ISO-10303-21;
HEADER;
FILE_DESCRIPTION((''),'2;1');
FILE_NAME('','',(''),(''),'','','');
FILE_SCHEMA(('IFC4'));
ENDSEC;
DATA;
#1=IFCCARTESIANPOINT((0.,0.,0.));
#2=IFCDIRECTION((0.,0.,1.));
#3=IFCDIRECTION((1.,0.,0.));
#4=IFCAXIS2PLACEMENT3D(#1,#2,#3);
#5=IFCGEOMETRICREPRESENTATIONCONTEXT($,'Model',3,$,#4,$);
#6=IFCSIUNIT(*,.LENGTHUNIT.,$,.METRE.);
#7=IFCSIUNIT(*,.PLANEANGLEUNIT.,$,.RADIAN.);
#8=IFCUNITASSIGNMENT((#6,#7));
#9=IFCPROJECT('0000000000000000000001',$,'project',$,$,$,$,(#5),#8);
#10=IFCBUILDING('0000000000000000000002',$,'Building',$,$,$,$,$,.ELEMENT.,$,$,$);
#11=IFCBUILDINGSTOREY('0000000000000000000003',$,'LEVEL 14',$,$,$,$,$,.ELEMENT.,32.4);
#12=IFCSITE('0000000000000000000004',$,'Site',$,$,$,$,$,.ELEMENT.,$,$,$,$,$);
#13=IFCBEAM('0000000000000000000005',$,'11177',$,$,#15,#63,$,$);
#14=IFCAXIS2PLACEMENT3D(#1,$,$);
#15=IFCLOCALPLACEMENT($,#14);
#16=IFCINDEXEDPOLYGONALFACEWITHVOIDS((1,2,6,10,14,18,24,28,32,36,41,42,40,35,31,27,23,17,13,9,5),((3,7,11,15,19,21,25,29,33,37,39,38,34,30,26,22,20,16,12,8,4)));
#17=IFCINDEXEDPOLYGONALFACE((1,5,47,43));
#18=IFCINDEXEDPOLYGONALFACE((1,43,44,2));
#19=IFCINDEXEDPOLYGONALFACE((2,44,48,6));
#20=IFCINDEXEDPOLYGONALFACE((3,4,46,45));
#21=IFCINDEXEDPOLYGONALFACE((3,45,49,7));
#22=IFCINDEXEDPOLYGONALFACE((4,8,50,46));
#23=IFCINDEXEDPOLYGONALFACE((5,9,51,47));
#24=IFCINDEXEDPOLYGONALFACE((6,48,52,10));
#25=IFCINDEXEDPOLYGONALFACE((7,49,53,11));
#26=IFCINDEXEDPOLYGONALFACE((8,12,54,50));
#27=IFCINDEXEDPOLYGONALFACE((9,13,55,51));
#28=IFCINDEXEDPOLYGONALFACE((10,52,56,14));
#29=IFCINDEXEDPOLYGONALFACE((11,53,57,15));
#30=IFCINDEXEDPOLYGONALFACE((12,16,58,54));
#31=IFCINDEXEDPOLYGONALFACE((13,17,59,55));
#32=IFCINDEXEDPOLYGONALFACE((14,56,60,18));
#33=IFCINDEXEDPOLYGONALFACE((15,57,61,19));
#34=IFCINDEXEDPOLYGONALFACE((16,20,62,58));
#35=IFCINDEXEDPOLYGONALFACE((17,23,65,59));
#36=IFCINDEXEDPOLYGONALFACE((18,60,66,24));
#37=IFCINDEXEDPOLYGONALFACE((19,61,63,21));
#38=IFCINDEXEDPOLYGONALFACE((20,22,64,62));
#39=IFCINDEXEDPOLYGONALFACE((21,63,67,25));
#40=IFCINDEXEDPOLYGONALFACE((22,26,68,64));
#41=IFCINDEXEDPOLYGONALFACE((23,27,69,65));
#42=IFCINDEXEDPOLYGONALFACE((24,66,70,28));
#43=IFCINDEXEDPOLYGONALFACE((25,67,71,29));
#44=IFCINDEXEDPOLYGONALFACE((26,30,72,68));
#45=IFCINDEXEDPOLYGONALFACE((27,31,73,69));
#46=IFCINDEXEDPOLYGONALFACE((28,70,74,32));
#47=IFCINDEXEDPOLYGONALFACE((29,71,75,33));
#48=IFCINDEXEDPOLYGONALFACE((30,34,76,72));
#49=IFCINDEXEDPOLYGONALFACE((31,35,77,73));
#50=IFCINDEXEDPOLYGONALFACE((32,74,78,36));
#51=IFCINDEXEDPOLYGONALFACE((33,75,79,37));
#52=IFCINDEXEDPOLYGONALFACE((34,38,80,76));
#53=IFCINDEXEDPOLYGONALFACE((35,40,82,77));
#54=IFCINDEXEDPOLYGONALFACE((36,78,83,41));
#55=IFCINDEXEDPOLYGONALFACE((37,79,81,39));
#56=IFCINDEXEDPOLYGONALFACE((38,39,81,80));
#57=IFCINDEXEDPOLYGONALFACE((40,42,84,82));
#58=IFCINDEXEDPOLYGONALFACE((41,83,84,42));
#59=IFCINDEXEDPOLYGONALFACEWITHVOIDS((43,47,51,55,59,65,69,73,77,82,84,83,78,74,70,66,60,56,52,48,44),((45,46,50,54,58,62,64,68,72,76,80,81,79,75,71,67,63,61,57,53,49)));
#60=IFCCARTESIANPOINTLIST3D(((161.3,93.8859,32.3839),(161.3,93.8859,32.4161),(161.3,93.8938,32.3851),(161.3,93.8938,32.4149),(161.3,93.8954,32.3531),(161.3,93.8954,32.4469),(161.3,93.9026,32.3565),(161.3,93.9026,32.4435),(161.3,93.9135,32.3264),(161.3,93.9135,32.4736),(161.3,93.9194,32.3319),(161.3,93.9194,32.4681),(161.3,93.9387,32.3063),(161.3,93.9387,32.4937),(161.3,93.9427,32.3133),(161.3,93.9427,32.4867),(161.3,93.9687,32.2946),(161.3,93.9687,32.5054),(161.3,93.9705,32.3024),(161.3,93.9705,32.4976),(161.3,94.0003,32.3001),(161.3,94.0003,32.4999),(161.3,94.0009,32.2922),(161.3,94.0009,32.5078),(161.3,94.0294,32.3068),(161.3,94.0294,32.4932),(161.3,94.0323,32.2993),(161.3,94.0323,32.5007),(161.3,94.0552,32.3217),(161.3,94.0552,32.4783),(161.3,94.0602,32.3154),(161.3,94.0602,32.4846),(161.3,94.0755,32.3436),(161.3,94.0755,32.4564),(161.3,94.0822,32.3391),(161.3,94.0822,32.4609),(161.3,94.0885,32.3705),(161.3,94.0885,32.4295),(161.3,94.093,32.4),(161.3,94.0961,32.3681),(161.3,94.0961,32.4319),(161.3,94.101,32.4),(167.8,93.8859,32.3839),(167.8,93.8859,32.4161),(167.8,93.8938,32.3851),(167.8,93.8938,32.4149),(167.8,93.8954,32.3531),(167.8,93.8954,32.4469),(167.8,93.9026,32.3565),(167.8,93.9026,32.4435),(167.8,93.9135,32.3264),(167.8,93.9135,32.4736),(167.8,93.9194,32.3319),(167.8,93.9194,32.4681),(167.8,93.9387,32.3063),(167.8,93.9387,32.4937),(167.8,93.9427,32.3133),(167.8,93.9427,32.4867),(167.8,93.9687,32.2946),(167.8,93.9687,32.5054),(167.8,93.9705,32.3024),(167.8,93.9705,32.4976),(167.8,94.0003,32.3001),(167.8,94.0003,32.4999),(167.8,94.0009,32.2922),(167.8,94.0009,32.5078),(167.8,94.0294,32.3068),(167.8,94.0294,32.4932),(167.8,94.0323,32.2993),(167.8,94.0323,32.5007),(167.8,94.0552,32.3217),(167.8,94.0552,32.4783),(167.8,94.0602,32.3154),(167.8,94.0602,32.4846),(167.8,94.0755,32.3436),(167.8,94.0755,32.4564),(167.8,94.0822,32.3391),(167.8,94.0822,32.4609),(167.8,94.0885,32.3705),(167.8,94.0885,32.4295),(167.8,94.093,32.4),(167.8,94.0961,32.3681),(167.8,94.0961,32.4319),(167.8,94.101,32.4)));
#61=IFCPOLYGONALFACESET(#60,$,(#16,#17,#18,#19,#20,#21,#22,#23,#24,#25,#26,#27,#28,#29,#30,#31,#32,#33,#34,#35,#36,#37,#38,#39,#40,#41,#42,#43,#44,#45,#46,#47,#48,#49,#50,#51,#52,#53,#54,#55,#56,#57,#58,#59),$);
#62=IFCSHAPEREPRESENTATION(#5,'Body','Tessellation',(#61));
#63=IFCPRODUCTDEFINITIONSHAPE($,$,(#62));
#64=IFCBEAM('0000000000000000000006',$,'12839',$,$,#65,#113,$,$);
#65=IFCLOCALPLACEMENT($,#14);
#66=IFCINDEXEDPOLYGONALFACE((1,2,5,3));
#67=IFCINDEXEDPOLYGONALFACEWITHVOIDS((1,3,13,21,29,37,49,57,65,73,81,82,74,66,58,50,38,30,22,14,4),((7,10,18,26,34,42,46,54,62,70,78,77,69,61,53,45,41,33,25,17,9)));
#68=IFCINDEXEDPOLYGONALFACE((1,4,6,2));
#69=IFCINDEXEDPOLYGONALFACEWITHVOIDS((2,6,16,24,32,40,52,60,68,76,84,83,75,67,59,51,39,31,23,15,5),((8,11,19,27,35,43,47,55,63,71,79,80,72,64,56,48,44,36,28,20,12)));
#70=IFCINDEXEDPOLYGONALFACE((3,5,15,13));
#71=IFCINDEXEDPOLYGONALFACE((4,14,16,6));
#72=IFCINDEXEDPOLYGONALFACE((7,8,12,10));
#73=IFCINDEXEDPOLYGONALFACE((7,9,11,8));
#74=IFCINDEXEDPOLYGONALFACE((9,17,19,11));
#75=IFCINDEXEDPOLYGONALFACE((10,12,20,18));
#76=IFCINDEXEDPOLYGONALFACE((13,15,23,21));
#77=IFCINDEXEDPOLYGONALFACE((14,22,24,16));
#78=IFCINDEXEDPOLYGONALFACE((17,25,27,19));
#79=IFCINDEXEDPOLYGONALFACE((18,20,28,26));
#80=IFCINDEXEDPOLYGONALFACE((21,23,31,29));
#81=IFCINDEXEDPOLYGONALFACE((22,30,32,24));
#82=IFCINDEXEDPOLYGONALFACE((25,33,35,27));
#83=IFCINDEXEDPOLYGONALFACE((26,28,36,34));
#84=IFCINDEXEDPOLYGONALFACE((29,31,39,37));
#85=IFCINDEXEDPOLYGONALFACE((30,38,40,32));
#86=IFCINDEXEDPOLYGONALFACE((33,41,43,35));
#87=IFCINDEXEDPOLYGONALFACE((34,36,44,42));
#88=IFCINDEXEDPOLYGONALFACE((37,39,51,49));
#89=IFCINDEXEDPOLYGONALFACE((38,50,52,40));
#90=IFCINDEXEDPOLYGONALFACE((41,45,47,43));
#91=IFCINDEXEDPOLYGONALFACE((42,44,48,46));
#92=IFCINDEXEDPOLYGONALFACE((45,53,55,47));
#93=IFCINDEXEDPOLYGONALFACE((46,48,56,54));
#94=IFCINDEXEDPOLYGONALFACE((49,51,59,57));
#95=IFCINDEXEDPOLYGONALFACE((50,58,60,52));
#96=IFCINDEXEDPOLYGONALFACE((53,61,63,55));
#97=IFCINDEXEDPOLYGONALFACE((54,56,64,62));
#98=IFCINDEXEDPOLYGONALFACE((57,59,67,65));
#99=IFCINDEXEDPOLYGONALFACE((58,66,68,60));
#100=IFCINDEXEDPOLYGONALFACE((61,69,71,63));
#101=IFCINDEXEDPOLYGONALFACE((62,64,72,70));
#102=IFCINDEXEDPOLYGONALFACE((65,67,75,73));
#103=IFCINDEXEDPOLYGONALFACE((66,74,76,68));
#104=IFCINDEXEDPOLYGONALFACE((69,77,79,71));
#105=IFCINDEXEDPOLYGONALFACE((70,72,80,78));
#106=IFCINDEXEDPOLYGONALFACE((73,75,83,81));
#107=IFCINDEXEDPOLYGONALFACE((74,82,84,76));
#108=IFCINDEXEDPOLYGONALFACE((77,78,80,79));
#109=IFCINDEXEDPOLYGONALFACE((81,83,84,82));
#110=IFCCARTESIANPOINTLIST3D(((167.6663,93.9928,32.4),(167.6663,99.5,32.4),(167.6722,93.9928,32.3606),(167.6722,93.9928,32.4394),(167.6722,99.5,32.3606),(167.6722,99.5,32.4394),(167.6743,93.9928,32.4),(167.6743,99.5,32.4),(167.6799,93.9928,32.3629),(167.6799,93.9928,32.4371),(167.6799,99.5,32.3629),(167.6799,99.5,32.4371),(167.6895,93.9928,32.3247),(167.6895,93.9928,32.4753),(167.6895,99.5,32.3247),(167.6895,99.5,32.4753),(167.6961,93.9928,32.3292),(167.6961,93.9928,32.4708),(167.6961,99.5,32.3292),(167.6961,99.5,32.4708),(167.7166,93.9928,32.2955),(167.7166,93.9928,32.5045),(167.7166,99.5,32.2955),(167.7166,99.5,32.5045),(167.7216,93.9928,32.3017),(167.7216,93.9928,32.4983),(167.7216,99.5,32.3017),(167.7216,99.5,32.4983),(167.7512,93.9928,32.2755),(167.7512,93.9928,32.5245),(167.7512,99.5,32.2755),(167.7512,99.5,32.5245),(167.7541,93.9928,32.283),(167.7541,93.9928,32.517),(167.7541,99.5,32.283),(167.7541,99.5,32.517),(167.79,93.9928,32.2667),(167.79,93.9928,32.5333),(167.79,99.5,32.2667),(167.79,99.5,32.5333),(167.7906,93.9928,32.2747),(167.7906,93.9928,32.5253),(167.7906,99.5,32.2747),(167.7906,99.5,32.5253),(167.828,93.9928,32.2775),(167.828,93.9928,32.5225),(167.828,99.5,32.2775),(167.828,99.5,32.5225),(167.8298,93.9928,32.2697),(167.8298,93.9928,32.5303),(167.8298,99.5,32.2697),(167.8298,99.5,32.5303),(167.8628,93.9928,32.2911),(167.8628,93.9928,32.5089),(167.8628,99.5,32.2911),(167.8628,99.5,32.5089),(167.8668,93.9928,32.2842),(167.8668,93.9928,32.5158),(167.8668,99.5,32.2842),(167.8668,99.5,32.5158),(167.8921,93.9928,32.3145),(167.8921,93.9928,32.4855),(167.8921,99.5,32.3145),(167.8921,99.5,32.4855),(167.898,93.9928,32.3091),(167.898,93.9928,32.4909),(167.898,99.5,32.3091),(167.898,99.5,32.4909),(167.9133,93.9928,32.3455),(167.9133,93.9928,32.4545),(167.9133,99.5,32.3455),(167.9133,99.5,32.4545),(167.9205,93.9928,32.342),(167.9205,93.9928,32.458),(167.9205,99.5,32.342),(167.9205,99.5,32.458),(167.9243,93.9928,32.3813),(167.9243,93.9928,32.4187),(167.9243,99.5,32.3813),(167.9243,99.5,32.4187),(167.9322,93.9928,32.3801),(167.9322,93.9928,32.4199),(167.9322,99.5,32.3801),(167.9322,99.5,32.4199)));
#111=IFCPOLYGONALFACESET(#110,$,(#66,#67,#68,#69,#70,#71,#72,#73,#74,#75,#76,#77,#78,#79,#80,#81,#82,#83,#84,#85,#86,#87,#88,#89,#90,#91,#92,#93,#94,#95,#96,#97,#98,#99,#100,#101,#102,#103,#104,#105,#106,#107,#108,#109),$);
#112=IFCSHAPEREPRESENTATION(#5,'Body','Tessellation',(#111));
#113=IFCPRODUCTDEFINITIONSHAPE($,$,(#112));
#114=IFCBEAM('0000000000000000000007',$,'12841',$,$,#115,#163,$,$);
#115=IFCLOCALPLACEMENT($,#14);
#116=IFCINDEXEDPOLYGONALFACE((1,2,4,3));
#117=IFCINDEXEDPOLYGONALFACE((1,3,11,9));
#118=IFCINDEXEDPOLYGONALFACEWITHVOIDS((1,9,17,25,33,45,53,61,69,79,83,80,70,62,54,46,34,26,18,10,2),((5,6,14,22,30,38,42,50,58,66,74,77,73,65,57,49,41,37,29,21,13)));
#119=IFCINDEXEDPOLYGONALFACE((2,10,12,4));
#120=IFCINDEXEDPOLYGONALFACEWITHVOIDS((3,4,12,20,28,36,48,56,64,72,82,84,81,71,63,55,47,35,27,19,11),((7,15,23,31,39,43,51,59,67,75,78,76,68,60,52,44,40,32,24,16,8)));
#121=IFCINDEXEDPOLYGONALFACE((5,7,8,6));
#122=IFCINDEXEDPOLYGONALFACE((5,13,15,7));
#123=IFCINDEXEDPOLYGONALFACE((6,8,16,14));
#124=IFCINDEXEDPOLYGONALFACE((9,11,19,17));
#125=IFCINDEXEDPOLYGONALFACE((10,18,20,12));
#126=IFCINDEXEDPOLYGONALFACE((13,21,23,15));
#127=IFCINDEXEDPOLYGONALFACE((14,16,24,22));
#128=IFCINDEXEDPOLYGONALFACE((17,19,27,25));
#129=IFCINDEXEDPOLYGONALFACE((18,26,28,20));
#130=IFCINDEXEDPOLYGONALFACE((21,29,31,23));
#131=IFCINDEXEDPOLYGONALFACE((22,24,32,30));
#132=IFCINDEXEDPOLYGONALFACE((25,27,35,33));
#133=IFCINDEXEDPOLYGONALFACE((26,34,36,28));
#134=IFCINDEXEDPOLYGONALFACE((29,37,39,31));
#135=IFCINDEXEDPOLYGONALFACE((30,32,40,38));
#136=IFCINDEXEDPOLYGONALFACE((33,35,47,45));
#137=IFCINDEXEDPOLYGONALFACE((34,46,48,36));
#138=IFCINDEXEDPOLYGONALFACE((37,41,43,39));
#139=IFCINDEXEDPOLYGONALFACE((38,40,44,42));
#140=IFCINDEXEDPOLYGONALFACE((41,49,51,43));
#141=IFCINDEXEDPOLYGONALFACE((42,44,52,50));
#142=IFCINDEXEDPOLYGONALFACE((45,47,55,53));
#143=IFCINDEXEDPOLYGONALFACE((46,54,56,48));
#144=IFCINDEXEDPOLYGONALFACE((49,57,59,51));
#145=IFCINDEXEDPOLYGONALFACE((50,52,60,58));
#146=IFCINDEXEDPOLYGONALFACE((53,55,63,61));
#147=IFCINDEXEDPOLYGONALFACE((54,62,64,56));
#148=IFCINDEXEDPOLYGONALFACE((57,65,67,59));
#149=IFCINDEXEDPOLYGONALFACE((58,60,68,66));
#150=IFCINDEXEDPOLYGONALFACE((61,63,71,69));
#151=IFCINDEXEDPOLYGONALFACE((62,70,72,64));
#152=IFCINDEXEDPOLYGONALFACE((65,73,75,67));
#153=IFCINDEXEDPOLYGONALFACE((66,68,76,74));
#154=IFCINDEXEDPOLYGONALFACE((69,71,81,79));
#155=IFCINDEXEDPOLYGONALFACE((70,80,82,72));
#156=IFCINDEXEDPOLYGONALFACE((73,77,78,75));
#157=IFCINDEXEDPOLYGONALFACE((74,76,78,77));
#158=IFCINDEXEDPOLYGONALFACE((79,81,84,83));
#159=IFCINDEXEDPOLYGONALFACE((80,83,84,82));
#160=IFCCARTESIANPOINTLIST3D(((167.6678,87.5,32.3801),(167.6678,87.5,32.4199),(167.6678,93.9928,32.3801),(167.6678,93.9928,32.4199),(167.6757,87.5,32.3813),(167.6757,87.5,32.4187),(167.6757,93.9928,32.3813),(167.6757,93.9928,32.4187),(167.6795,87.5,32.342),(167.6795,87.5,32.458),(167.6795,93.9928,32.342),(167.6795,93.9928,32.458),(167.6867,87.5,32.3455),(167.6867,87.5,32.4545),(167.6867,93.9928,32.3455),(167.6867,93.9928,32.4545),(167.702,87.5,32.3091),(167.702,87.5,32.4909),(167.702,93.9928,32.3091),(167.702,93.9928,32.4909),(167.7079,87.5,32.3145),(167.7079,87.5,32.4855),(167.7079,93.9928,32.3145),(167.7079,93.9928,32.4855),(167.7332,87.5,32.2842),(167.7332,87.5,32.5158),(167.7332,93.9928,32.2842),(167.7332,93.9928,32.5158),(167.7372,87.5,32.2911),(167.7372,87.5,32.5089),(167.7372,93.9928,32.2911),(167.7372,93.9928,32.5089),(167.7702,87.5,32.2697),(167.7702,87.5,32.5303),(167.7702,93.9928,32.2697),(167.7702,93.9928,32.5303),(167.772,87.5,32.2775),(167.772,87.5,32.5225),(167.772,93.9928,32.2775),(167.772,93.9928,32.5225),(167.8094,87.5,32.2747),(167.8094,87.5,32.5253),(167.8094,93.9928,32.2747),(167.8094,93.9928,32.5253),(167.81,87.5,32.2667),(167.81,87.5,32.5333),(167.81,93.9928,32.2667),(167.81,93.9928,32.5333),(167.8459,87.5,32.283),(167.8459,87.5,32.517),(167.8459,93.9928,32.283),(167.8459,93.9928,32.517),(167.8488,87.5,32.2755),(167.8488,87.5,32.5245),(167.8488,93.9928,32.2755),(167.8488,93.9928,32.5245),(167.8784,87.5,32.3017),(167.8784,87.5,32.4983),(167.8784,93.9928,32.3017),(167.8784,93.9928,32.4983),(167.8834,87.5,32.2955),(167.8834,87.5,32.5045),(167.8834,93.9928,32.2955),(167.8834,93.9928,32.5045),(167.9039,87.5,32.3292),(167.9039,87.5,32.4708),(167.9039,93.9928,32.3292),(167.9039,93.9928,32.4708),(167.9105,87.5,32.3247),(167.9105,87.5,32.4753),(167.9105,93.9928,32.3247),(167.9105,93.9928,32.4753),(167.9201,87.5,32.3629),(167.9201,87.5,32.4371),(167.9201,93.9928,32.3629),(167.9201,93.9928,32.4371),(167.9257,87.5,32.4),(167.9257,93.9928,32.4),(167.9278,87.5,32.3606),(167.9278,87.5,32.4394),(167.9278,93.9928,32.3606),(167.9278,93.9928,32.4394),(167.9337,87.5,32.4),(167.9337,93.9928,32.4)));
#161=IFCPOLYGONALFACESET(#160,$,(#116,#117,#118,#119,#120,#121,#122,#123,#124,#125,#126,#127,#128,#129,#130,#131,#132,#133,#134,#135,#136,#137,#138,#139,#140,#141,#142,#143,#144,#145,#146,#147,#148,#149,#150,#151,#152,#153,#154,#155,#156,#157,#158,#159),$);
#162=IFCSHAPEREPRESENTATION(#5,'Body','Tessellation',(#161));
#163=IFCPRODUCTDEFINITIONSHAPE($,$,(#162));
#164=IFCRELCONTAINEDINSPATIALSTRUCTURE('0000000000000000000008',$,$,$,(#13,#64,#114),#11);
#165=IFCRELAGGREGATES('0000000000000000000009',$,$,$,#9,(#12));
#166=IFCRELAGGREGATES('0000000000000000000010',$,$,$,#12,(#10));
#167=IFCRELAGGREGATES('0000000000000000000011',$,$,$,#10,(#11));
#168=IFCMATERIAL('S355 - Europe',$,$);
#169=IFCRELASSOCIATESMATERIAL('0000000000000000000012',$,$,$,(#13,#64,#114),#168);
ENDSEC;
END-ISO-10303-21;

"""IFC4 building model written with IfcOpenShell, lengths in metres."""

from ifc_helpers import new_model, si_unit, frame, origin_with_axes, origin_2d_with_axis, place, context, project, spatial, hollow_circle, extrude, material, material_profile, profile_set, profile_usage, element, save


model = new_model("IFC4")

# Units and contexts
model_context = context("Model", 3, world=origin_with_axes())
ifc_project = project(units=[si_unit("LENGTHUNIT", "METRE"), si_unit("PLANEANGLEUNIT", "RADIAN")], contexts=[model_context])

# Site, building, storey
site = spatial("IfcSite", under=ifc_project, Name="Site", CompositionType="ELEMENT")
building = spatial("IfcBuilding", under=site, Name="Building", CompositionType="ELEMENT")
storey = spatial("IfcBuildingStorey", under=building, Name="LEVEL 14", CompositionType="ELEMENT", Elevation=32.4)

# Shared definitions
ifc_material = material(Name="S355 - Europe")

# Beams
ifc_material_profile_1 = material_profile(ifc_material, hollow_circle(Radius=0.1081, WallThickness=0.008, at=origin_2d_with_axis()))
ifc_profile_set_1 = profile_set([ifc_material_profile_1])
ifc_profile_usage_1 = profile_usage(ifc_profile_set_1, cardinal=10)
beam_1_placement = place(None, frame((161.3, 93.9928, 32.4), z_axis=(1.0, 0.0, 0.0), x_axis=(0.0, 1.0, 0.0)))
element("IfcBeam", 1, at=beam_1_placement, inside=storey, material=ifc_profile_usage_1, Name="11177", context=model_context, shape_type="SweptSolid", body=[
    extrude(hollow_circle(Radius=0.1081, WallThickness=0.008, at=origin_2d_with_axis()), origin_with_axes(), (0.0, 0.0, 1.0), 6.5),
])
ifc_material_profile_2 = material_profile(ifc_material, hollow_circle(Radius=0.1337, WallThickness=0.008, at=origin_2d_with_axis()))
ifc_profile_set_2 = profile_set([ifc_material_profile_2])
ifc_profile_usage_2 = profile_usage(ifc_profile_set_2, cardinal=10)
beam_2_placement = place(None, frame((167.8, 93.9928, 32.4), z_axis=(0.0, 1.0, 0.0), x_axis=(-1.0, 0.0, 0.0)))
element("IfcBeam", 2, at=beam_2_placement, inside=storey, material=ifc_profile_usage_2, Name="12839", context=model_context, shape_type="SweptSolid", body=[
    extrude(hollow_circle(Radius=0.1337, WallThickness=0.008, at=origin_2d_with_axis()), origin_with_axes(), (0.0, 0.0, 1.0), 5.5072),
])
ifc_material_profile_3 = material_profile(ifc_material, hollow_circle(Radius=0.1337, WallThickness=0.008, at=origin_2d_with_axis()))
ifc_profile_set_3 = profile_set([ifc_material_profile_3])
ifc_profile_usage_3 = profile_usage(ifc_profile_set_3, cardinal=10)
beam_3_placement = place(None, frame((167.8, 93.9928, 32.4), z_axis=(0.0, -1.0, 0.0), x_axis=(1.0, 0.0, 0.0)))
element("IfcBeam", 3, at=beam_3_placement, inside=storey, material=ifc_profile_usage_3, Name="12841", context=model_context, shape_type="SweptSolid", body=[
    extrude(hollow_circle(Radius=0.1337, WallThickness=0.008, at=origin_2d_with_axis()), origin_with_axes(), (0.0, 0.0, 1.0), 6.4928),
])

save(model, "model.ifc")
